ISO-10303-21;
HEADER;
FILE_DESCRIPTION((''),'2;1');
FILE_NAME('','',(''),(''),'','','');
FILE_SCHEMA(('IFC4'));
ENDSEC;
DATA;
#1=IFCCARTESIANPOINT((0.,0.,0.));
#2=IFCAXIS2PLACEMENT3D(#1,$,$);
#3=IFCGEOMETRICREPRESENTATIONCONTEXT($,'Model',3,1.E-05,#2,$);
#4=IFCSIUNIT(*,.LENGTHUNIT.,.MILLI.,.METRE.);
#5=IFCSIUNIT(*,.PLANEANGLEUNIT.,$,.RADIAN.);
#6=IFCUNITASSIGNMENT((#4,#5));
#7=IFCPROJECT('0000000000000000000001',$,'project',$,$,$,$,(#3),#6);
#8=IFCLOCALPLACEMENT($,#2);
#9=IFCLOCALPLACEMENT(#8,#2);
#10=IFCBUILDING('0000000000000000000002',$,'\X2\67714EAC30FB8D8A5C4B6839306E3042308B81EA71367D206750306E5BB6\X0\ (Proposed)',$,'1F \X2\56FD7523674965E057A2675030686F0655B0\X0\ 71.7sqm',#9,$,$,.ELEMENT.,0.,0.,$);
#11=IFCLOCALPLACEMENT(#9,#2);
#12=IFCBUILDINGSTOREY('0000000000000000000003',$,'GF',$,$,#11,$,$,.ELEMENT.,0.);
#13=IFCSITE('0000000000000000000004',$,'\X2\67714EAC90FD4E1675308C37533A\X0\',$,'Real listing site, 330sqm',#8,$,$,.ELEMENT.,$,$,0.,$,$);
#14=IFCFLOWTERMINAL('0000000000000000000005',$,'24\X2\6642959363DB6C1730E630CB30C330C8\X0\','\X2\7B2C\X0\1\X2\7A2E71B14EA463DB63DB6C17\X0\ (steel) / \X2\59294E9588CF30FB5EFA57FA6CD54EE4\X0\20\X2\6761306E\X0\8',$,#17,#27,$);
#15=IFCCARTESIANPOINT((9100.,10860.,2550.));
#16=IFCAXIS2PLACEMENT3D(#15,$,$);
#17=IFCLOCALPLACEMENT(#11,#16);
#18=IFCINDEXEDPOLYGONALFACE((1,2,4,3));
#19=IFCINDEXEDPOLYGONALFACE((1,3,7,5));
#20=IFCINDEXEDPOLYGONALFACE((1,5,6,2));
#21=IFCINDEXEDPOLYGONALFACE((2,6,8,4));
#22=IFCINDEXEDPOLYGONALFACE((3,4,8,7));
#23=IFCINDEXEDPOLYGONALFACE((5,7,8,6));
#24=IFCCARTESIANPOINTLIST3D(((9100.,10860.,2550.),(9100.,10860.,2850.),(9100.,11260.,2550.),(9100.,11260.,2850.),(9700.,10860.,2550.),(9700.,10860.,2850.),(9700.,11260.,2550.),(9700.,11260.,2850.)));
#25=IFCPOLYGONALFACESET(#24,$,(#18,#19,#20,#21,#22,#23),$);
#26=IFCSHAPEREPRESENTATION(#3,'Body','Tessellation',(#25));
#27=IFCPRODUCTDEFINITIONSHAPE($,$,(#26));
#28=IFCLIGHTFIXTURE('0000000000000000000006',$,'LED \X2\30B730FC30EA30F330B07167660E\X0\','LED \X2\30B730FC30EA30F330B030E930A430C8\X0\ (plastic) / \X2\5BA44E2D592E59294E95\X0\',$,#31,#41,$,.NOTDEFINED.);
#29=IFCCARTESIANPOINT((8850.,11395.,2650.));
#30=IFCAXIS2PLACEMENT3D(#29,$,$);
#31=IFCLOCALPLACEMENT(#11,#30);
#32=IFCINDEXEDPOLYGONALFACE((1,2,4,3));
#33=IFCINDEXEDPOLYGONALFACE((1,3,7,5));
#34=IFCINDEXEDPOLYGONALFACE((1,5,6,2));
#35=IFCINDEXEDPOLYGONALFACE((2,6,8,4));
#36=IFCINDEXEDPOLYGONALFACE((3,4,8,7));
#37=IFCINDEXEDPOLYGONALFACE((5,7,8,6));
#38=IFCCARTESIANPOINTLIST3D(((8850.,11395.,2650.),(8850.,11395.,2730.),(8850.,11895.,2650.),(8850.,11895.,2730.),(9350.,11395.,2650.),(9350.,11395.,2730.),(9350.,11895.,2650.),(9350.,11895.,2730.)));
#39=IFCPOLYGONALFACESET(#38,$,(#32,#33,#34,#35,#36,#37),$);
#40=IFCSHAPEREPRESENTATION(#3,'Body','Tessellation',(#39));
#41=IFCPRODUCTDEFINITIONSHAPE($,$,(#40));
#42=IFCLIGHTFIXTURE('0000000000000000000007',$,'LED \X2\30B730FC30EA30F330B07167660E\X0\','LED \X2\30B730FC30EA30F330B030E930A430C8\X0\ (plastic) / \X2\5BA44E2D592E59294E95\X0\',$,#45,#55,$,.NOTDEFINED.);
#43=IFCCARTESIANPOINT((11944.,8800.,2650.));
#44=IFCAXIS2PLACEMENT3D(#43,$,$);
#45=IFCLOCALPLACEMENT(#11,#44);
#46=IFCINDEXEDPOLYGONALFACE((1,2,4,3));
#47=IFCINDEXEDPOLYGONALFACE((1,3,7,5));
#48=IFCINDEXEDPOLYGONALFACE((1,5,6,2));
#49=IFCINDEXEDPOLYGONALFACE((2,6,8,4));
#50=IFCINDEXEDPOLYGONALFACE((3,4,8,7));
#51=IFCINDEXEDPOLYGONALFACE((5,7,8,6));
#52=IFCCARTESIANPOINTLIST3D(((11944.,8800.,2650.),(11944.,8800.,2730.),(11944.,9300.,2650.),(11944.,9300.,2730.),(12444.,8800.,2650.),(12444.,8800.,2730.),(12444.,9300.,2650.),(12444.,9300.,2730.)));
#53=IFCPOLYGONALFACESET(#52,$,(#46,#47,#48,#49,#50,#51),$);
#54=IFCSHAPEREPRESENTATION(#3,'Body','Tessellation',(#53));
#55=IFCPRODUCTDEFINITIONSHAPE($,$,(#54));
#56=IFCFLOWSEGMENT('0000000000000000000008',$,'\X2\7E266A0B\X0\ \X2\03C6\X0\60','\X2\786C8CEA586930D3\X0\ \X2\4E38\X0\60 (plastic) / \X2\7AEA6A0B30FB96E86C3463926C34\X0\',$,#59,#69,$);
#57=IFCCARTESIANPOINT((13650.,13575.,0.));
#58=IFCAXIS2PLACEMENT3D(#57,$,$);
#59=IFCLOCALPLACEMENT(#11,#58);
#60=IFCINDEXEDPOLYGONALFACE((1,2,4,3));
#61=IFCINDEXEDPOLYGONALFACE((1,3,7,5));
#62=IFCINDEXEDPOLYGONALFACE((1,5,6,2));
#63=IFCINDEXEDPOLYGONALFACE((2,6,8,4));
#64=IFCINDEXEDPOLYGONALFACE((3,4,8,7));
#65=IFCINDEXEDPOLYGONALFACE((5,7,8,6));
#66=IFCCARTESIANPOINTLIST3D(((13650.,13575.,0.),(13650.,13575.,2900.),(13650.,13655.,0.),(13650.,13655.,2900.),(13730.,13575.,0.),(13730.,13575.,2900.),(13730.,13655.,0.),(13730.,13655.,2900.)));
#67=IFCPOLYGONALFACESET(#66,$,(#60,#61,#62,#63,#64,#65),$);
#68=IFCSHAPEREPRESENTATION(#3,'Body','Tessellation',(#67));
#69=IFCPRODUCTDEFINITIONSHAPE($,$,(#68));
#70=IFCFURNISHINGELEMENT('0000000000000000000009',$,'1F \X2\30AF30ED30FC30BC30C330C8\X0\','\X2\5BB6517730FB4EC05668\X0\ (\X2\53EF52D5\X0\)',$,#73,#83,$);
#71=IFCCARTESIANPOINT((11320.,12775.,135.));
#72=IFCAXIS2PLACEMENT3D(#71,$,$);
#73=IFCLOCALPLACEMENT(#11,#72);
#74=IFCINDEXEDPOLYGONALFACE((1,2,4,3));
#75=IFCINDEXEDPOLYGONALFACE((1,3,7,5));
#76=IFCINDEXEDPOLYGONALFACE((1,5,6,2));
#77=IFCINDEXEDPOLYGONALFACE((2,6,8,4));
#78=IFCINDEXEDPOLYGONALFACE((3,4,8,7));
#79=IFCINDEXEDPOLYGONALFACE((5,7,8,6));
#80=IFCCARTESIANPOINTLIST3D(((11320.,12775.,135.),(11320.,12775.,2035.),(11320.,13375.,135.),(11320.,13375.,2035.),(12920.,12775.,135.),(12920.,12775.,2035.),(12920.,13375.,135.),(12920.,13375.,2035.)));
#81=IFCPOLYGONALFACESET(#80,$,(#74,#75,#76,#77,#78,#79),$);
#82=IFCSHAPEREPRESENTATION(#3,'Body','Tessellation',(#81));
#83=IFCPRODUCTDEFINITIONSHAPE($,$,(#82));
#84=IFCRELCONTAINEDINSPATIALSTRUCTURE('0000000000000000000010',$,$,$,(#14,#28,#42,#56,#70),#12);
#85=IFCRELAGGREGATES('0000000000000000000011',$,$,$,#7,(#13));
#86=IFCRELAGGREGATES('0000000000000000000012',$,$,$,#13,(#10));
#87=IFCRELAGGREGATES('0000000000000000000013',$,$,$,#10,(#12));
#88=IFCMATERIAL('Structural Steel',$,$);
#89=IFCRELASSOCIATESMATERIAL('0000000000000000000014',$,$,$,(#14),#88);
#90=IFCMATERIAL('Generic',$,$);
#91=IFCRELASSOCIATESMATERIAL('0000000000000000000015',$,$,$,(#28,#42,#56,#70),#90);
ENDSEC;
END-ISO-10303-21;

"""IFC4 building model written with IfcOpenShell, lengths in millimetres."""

from ifc_helpers import new_model, si_unit, frame, frame_2d, origin, place, context, project, spatial, rectangle, extrude, material, element, save


model = new_model("IFC4")

# Units and contexts
model_context = context("Model", 3, precision=1e-05, world=origin())
ifc_project = project(units=[si_unit("LENGTHUNIT", "METRE", prefix="MILLI"), si_unit("PLANEANGLEUNIT", "RADIAN")], contexts=[model_context])

# Site, building, storey
site_placement = place(None, origin())
site = spatial("IfcSite", under=ifc_project, at=site_placement, Name="東京都世田谷区", ObjectType="Real listing site, 330sqm", CompositionType="ELEMENT", RefElevation=0.0)
building_placement = place(site_placement, origin())
building = spatial("IfcBuilding", under=site, at=building_placement, Name="東京・越屋根のある自然素材の家 (Proposed)", ObjectType="1F 国産杉无垢材と漆喰 71.7sqm", CompositionType="ELEMENT", ElevationOfRefHeight=0.0, ElevationOfTerrain=0.0)
storey_placement = place(building_placement, origin())
storey = spatial("IfcBuildingStorey", under=building, at=storey_placement, Name="GF", CompositionType="ELEMENT", Elevation=0.0)

# Shared definitions
ifc_material_1 = material(Name="Generic")

# Flow terminal
ifc_material_2 = material(Name="Structural Steel")
flow_terminal_placement = place(storey_placement, frame((9100.0, 10860.0, 2550.0)))
element("IfcFlowTerminal", 1, at=flow_terminal_placement, inside=storey, material=ifc_material_2, Name="24時間換気ユニット", Description="第1種熱交換換気 (steel) / 天井裏・建基法令20条の8", context=model_context, shape_type="SweptSolid", body=[
    extrude(rectangle(XDim=600.0, YDim=400.0, at=frame_2d((300.0, 200.0))), frame((9100.0, 10860.0, 2550.0)), (0.0, 0.0, 1.0), 300.0),
])

# Light fixtures
light_fixture_1_placement = place(storey_placement, frame((8850.0, 11395.0, 2650.0)))
element("IfcLightFixture", 2, at=light_fixture_1_placement, inside=storey, material=ifc_material_1, Name="LED シーリング照明", Description="LED シーリングライト (plastic) / 室中央天井", PredefinedType="NOTDEFINED", context=model_context, shape_type="SweptSolid", body=[
    extrude(rectangle(XDim=500.0, YDim=500.0, at=frame_2d((250.0, 250.0))), frame((8850.0, 11395.0, 2650.0)), (0.0, 0.0, 1.0), 80.0),
])
light_fixture_2_placement = place(storey_placement, frame((11944.0, 8800.0, 2650.0)))
element("IfcLightFixture", 3, at=light_fixture_2_placement, inside=storey, material=ifc_material_1, Name="LED シーリング照明", Description="LED シーリングライト (plastic) / 室中央天井", PredefinedType="NOTDEFINED", context=model_context, shape_type="SweptSolid", body=[
    extrude(rectangle(XDim=500.0, YDim=500.0, at=frame_2d((250.0, 250.0))), frame((11944.0, 8800.0, 2650.0)), (0.0, 0.0, 1.0), 80.0),
])

# Flow segment
flow_segment_placement = place(storey_placement, frame((13650.0, 13575.0, 0.0)))
element("IfcFlowSegment", 4, at=flow_segment_placement, inside=storey, material=ifc_material_1, Name="縦樋 φ60", Description="硬質塩ビ 丸60 (plastic) / 竪樋・雨水排水", context=model_context, shape_type="SweptSolid", body=[
    extrude(rectangle(XDim=80.0, YDim=80.0, at=frame_2d((40.0, 40.0))), frame((13650.0, 13575.0, 0.0)), (0.0, 0.0, 1.0), 2900.0),
])

# Furnishing element
furnishing_placement = place(storey_placement, frame((11320.0, 12775.0, 135.0)))
element("IfcFurnishingElement", 5, at=furnishing_placement, inside=storey, material=ifc_material_1, Name="1F クローゼット", Description="家具・什器 (可動)", context=model_context, shape_type="SweptSolid", body=[
    extrude(rectangle(XDim=1600.0, YDim=600.0, at=frame_2d((800.0, 300.0))), frame((11320.0, 12775.0, 135.0)), (0.0, 0.0, 1.0), 1900.0),
])

save(model, "model.ifc")
